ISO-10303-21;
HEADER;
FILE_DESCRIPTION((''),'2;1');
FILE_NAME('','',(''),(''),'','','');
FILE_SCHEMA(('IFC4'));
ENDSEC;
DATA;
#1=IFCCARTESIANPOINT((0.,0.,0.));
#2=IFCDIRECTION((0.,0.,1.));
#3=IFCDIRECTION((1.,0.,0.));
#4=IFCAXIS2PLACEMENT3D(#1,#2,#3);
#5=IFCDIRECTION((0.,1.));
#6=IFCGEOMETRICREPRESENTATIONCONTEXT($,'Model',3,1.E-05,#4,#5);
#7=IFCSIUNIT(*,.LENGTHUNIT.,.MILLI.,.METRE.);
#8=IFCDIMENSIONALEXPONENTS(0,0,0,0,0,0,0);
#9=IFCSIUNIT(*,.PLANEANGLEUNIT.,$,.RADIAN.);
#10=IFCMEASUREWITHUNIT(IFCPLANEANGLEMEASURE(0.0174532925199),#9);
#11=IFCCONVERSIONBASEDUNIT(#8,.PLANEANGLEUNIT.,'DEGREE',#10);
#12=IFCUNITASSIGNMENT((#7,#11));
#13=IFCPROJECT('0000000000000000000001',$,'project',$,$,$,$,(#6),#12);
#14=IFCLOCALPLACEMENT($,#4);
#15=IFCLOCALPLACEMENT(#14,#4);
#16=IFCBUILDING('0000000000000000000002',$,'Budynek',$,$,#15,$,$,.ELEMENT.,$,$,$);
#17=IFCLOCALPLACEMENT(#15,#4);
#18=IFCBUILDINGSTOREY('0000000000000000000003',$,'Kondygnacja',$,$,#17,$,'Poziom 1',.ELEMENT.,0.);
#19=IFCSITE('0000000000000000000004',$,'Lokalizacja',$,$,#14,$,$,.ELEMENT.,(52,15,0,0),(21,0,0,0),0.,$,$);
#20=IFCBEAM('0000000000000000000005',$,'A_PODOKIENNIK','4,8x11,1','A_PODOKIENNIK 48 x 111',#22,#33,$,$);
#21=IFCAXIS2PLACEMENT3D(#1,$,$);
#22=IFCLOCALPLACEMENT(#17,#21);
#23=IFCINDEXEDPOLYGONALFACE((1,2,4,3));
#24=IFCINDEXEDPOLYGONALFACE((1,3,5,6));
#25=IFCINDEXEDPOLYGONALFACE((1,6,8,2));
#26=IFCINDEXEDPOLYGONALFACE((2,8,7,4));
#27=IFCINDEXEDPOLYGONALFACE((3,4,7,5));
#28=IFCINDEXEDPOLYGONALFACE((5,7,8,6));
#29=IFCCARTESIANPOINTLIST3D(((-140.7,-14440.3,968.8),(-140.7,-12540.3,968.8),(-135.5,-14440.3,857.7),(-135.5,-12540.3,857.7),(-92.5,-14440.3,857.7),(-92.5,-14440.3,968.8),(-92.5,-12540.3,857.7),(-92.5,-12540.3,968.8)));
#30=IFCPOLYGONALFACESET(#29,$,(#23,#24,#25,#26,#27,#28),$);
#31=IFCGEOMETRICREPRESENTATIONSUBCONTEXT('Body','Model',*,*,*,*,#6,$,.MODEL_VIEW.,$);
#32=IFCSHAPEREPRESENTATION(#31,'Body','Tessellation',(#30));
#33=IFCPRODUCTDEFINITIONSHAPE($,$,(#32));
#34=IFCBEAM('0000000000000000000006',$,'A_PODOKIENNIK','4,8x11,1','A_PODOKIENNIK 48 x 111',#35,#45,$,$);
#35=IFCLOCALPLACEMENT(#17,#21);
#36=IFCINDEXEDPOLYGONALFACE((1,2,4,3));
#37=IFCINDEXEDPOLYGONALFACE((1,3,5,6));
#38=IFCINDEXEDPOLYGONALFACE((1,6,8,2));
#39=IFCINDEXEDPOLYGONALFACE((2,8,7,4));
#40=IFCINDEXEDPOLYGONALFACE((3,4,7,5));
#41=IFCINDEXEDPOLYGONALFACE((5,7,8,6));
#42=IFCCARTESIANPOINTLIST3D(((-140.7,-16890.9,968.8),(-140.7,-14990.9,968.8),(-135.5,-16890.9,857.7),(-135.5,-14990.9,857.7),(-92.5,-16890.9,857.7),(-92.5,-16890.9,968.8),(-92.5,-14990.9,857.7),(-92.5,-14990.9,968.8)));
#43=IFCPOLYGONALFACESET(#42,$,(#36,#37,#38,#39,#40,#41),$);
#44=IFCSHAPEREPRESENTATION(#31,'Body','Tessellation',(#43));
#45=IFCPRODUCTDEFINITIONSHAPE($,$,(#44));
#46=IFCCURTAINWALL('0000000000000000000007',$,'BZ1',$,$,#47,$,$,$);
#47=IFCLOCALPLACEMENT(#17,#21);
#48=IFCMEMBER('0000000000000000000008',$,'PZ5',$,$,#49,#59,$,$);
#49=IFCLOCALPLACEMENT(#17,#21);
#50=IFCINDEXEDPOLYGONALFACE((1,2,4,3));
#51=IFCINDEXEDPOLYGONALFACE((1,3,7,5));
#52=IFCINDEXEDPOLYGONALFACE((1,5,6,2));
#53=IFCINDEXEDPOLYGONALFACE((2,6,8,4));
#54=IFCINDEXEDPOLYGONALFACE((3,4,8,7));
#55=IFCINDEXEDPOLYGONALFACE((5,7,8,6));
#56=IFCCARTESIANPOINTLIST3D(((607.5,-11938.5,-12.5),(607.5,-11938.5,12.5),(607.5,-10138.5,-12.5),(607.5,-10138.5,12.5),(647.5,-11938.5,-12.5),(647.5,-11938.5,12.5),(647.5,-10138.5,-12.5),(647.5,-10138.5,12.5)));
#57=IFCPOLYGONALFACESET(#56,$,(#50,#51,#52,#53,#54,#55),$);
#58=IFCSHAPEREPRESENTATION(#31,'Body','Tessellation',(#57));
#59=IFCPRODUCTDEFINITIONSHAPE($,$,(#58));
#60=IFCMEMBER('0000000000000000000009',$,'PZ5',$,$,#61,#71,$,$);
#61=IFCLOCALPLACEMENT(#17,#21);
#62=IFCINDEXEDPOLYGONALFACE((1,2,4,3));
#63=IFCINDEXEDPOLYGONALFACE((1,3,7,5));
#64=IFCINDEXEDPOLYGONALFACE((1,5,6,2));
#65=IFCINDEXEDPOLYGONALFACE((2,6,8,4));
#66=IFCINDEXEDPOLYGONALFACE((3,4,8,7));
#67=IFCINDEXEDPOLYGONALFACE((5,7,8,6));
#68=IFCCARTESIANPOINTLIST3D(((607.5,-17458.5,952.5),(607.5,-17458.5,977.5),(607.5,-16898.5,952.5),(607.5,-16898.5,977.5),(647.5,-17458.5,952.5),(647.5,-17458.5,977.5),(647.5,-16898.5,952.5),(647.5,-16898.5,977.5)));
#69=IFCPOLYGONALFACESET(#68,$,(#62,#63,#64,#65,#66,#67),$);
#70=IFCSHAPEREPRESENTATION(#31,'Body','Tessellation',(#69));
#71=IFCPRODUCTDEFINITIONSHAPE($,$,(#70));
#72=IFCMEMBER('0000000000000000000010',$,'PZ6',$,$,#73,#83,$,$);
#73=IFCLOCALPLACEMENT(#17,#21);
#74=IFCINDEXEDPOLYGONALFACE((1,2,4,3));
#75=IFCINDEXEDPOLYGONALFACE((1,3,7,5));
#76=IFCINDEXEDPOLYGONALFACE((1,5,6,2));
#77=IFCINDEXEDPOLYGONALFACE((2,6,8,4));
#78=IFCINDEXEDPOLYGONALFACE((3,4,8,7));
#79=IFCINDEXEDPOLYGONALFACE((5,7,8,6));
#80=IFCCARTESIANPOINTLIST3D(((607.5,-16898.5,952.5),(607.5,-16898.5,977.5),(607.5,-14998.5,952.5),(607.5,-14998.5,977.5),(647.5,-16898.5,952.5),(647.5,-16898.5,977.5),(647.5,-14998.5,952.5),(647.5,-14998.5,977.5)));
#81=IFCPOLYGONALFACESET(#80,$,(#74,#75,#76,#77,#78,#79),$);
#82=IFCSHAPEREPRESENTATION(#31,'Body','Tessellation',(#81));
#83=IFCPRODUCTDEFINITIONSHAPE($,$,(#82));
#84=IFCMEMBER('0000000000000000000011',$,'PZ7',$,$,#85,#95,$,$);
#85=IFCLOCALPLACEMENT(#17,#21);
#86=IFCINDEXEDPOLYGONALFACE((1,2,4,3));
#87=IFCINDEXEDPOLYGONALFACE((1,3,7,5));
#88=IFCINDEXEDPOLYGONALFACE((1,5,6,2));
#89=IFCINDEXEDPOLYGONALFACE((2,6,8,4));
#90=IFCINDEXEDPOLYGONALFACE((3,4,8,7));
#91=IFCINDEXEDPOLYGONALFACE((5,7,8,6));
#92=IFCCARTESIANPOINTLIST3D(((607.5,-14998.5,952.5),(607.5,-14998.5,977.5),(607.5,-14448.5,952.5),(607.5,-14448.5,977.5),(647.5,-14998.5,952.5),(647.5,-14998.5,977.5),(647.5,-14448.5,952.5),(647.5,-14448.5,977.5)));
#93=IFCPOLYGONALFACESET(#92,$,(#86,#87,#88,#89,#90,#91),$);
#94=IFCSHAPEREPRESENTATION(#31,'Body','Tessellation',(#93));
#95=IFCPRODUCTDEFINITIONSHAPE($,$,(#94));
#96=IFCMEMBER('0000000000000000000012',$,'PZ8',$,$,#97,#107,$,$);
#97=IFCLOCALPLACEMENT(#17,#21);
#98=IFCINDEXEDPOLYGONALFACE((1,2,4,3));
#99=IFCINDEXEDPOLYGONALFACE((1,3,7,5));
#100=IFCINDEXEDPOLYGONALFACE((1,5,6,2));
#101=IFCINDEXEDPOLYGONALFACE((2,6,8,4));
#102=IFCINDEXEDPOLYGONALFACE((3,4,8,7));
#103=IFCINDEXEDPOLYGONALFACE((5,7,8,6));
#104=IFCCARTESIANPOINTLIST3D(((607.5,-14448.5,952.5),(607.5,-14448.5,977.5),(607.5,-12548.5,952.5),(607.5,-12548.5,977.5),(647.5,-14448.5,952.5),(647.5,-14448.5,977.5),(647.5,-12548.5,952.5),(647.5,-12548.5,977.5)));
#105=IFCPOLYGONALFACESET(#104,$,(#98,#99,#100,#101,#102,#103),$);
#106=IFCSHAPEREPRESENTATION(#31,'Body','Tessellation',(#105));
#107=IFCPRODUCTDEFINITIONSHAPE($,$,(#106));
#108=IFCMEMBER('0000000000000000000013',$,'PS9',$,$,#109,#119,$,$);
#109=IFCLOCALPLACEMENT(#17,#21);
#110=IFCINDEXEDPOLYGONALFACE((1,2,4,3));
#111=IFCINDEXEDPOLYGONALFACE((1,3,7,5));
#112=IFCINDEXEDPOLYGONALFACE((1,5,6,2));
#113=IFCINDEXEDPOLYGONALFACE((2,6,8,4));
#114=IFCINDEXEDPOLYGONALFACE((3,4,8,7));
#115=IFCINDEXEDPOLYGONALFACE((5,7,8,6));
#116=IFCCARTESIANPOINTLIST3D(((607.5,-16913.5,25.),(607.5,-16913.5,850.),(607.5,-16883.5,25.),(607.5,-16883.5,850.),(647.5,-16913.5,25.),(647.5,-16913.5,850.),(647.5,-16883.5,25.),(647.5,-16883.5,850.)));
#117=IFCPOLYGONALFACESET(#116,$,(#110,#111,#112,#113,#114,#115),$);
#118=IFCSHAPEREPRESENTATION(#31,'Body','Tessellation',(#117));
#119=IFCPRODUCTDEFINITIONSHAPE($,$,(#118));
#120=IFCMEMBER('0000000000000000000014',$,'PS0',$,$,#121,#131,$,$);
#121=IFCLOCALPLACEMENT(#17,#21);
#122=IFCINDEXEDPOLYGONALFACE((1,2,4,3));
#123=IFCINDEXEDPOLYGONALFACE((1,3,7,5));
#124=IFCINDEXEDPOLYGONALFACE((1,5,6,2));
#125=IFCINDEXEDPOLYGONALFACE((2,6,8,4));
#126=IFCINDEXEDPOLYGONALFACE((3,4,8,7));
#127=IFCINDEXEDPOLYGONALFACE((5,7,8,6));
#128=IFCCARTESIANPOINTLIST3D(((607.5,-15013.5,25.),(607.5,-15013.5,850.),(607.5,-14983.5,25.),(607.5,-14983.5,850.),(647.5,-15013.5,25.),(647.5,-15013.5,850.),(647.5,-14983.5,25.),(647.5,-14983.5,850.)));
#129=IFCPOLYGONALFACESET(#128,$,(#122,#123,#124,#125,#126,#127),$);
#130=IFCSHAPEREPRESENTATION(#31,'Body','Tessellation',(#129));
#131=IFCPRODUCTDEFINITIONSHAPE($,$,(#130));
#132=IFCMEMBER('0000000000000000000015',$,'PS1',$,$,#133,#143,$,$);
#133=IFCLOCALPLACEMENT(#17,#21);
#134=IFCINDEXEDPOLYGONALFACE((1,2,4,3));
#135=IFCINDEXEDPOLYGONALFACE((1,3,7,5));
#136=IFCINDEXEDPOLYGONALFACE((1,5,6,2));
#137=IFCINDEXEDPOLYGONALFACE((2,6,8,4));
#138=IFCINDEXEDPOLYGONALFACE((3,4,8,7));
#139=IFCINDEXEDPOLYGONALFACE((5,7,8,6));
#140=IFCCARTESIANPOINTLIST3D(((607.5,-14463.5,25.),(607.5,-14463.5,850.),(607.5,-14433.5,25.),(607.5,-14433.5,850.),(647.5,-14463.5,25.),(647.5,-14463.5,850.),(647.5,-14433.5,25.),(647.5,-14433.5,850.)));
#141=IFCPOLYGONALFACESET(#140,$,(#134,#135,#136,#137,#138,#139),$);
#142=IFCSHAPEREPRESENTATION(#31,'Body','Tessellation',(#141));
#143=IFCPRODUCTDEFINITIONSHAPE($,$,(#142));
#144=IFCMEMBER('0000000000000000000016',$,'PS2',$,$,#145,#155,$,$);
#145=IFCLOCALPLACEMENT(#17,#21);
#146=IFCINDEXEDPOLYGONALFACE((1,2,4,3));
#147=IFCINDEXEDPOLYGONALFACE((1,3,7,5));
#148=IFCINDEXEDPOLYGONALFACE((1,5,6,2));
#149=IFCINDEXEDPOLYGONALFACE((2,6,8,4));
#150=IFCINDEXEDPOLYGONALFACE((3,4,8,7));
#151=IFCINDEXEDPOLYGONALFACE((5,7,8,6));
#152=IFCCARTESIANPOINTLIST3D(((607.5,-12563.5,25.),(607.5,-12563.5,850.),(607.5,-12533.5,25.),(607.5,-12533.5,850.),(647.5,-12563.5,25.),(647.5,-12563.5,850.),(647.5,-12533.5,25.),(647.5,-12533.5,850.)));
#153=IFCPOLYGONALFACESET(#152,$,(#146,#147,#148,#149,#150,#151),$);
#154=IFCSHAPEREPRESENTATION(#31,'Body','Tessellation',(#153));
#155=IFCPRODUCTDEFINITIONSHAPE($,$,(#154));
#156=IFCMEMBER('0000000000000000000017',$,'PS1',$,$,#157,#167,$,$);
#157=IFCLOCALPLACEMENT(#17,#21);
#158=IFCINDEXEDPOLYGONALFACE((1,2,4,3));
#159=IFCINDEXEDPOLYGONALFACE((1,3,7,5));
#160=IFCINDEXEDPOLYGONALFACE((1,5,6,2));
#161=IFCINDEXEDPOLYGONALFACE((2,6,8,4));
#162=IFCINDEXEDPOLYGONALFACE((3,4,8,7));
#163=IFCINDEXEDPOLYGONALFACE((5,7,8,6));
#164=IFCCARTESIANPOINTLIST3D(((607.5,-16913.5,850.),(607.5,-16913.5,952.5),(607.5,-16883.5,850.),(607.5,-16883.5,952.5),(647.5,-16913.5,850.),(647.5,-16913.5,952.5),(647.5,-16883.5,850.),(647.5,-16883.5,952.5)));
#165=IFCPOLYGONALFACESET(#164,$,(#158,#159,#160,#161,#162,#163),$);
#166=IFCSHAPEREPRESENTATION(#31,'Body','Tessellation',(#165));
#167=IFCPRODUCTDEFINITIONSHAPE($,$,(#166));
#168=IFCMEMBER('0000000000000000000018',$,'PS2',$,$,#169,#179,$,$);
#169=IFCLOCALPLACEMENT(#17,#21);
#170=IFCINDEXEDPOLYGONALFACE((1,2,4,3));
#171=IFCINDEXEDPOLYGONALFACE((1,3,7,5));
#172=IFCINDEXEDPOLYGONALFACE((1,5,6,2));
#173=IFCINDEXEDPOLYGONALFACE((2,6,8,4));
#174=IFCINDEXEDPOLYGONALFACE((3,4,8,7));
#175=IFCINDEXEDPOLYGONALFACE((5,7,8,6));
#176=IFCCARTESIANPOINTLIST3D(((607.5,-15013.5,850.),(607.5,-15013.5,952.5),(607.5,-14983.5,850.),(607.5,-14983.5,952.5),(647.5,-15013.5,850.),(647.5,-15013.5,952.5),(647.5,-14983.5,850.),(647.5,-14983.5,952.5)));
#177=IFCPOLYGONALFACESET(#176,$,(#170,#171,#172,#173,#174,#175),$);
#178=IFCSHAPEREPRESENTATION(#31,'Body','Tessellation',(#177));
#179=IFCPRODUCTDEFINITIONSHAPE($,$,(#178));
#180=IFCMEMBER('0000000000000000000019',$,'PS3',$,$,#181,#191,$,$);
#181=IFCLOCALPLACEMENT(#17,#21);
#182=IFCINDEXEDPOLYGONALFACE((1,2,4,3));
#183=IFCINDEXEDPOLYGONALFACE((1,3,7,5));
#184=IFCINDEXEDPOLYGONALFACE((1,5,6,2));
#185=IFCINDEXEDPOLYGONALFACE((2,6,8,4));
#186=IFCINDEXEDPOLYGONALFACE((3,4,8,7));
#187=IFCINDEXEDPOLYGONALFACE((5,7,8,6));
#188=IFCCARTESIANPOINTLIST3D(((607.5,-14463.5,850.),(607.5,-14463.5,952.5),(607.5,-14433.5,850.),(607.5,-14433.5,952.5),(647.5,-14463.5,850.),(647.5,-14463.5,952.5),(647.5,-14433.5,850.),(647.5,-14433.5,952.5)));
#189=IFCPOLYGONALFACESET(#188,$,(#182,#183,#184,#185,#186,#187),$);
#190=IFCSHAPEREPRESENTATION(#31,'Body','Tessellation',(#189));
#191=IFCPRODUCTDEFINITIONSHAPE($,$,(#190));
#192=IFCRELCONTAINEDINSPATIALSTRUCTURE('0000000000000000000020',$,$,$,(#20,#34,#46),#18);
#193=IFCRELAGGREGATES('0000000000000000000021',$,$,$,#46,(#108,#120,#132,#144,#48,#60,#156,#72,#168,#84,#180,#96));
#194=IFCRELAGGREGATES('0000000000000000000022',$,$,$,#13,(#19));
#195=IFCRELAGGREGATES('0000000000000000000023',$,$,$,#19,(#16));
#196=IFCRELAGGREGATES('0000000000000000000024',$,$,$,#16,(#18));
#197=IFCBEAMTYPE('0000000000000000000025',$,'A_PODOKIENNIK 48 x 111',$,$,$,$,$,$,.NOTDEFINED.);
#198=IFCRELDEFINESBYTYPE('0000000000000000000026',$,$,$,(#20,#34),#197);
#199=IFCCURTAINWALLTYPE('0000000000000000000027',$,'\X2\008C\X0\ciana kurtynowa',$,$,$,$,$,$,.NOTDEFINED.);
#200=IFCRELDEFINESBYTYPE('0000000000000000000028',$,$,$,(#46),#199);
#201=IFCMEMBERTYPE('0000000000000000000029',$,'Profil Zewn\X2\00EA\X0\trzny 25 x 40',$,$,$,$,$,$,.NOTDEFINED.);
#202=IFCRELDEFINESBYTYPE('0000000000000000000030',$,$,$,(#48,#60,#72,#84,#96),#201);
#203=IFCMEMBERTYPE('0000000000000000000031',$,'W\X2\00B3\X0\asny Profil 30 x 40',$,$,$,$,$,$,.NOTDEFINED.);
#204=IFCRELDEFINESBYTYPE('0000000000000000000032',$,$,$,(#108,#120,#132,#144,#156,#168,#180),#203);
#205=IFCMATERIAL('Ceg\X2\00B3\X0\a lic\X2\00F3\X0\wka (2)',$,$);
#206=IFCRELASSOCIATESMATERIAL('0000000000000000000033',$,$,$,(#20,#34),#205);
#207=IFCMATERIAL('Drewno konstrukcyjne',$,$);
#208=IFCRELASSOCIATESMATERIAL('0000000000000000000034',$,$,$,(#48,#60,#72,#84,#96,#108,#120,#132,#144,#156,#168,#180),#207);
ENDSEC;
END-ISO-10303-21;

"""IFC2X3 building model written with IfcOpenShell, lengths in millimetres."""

from ifc_helpers import new_model, entity, si_unit, converted_unit, direction, frame, origin_with_axes, place, context, subcontext, project, spatial, polyline, outline, extrude, material, type_object, element, aggregate, save


model = new_model("IFC2X3")

# Units and contexts
model_context = context("Model", 3, precision=1e-05, world=origin_with_axes(), true_north=direction((0.0, 1.0)))
body_context = subcontext(model_context, "Body", "Model", "MODEL_VIEW")
ifc_project = project(units=[si_unit("LENGTHUNIT", "METRE", prefix="MILLI"), converted_unit("PLANEANGLEUNIT", "DEGREE", entity("IfcPlaneAngleMeasure", 0.0174532925199), si_unit("PLANEANGLEUNIT", "RADIAN"), dimensions=[0, 0, 0, 0, 0, 0, 0])], contexts=[model_context])

# Site, building, storey
site_placement = place(None, origin_with_axes())
site = spatial("IfcSite", under=ifc_project, at=site_placement, Name="Lokalizacja", CompositionType="ELEMENT", RefLatitude=(52, 15, 0, 0), RefLongitude=(21, 0, 0, 0), RefElevation=0.0)
building_placement = place(site_placement, origin_with_axes())
building = spatial("IfcBuilding", under=site, at=building_placement, Name="Budynek", CompositionType="ELEMENT")
storey_placement = place(building_placement, origin_with_axes())
storey = spatial("IfcBuildingStorey", under=building, at=storey_placement, Name="Kondygnacja", LongName="Poziom 1", CompositionType="ELEMENT", Elevation=0.0)

# Beams
ifc_material_1 = material(Name="Ceg³a licówka (2)")
beam_type = type_object("IfcBeamType", Name="A_PODOKIENNIK 48 x 111", PredefinedType="NOTDEFINED")
for number, where, z_axis, x_axis, name in (
    (1, (-92.5, -12540.3, 857.7), (0.0, 0.0, 1.0), (-1.0, 0.0, 0.0), "A_PODOKIENNIK"),
    (2, (-92.5, -14990.9, 857.7), (0.0, 0.0, 1.0), (-1.0, 0.0, 0.0), "A_PODOKIENNIK"),
):
    element("IfcBeam", number, at=place(storey_placement, frame(where, z_axis=z_axis, x_axis=x_axis)), inside=storey, type_object=beam_type, material=ifc_material_1, Name=name, Description="4,8x11,1", ObjectType="A_PODOKIENNIK 48 x 111", context=body_context, shape_type="SweptSolid", body=[
        extrude(outline(polyline([(0.0, 0.0), (43.0, 0.0), (48.2, 111.1), (0.0, 111.1), (0.0, 0.0)])), frame((0.0, 1900.0, 0.0), z_axis=(0.0, -1.0, 0.0), x_axis=(1.0, 0.0, 0.0)), (0.0, 0.0, 1.0), 1900.0),
    ])

# Curtain wall, members
curtain_wall_type = type_object("IfcCurtainWallType", Name="\u008cciana kurtynowa", PredefinedType="NOTDEFINED")
curtain_wall_placement = place(storey_placement, frame((647.5, -18408.5, 0.0), z_axis=(0.0, 0.0, 1.0), x_axis=(1.0, 0.0, 0.0)))
curtain_wall = element("IfcCurtainWall", 3, at=curtain_wall_placement, inside=storey, type_object=curtain_wall_type, Name="BZ1")
ifc_material_2 = material(Name="Drewno konstrukcyjne")
member_type_1 = type_object("IfcMemberType", Name="Profil Zewnêtrzny 25 x 40", PredefinedType="NOTDEFINED")
member_1_placement = place(curtain_wall_placement, frame((0.0, 6470.0, 0.0), z_axis=(0.0, 1.0, 0.0), x_axis=(0.0, 0.0, 1.0)))
member_1 = element("IfcMember", 4, at=member_1_placement, type_object=member_type_1, material=ifc_material_2, Name="PZ5", context=body_context, shape_type="SweptSolid", body=[
    extrude(outline(polyline([(-40.0, -12.5), (0.0, -12.5), (0.0, 12.5), (-40.0, 12.5), (-40.0, -12.5)])), frame((0.0, 0.0, 0.0), z_axis=(0.0, 0.0, 1.0), x_axis=(0.0, 1.0, 0.0)), (0.0, 0.0, 1.0), 1800.0),
])
member_2_placement = place(curtain_wall_placement, frame((0.0, 1510.0, 965.0), z_axis=(0.0, -1.0, 0.0), x_axis=(0.0, 0.0, -1.0)))
member_2 = element("IfcMember", 5, at=member_2_placement, type_object=member_type_1, material=ifc_material_2, Name="PZ5", context=body_context, shape_type="SweptSolid", body=[
    extrude(outline(polyline([(40.0, 12.5), (0.0, 12.5), (0.0, -12.5), (40.0, -12.5), (40.0, 12.5)])), frame((0.0, 0.0, 0.0), z_axis=(0.0, 0.0, 1.0), x_axis=(0.0, -1.0, 0.0)), (0.0, 0.0, 1.0), 560.0),
])
member_3_placement = place(curtain_wall_placement, frame((0.0, 3410.0, 965.0), z_axis=(0.0, -1.0, 0.0), x_axis=(0.0, 0.0, -1.0)))
member_3 = element("IfcMember", 6, at=member_3_placement, type_object=member_type_1, material=ifc_material_2, Name="PZ6", context=body_context, shape_type="SweptSolid", body=[
    extrude(outline(polyline([(40.0, 12.5), (0.0, 12.5), (0.0, -12.5), (40.0, -12.5), (40.0, 12.5)])), frame((0.0, 0.0, 0.0), z_axis=(0.0, 0.0, 1.0), x_axis=(0.0, -1.0, 0.0)), (0.0, 0.0, 1.0), 1900.0),
])
member_4_placement = place(curtain_wall_placement, frame((0.0, 3960.0, 965.0), z_axis=(0.0, -1.0, 0.0), x_axis=(0.0, 0.0, -1.0)))
member_4 = element("IfcMember", 7, at=member_4_placement, type_object=member_type_1, material=ifc_material_2, Name="PZ7", context=body_context, shape_type="SweptSolid", body=[
    extrude(outline(polyline([(40.0, 12.5), (0.0, 12.5), (0.0, -12.5), (40.0, -12.5), (40.0, 12.5)])), frame((0.0, 0.0, 0.0), z_axis=(0.0, 0.0, 1.0), x_axis=(0.0, -1.0, 0.0)), (0.0, 0.0, 1.0), 550.0),
])
member_5_placement = place(curtain_wall_placement, frame((0.0, 5860.0, 965.0), z_axis=(0.0, -1.0, 0.0), x_axis=(0.0, 0.0, -1.0)))
member_5 = element("IfcMember", 8, at=member_5_placement, type_object=member_type_1, material=ifc_material_2, Name="PZ8", context=body_context, shape_type="SweptSolid", body=[
    extrude(outline(polyline([(40.0, 12.5), (0.0, 12.5), (0.0, -12.5), (40.0, -12.5), (40.0, 12.5)])), frame((0.0, 0.0, 0.0), z_axis=(0.0, 0.0, 1.0), x_axis=(0.0, -1.0, 0.0)), (0.0, 0.0, 1.0), 1900.0),
])
member_type_2 = type_object("IfcMemberType", Name="W³asny Profil 30 x 40", PredefinedType="NOTDEFINED")
member_6_placement = place(curtain_wall_placement, frame((0.0, 1510.0, 0.0), z_axis=(0.0, 0.0, 1.0), x_axis=(0.0, -1.0, 0.0)))
member_6 = element("IfcMember", 9, at=member_6_placement, type_object=member_type_2, material=ifc_material_2, Name="PS9", context=body_context, shape_type="SweptSolid", body=[
    extrude(outline(polyline([(-40.0, -15.0), (0.0, -15.0), (0.0, 15.0), (-40.0, 15.0), (-40.0, -15.0)])), frame((0.0, 0.0, 25.0), z_axis=(0.0, 0.0, 1.0), x_axis=(0.0, 1.0, 0.0)), (0.0, 0.0, 1.0), 825.0),
])
member_7_placement = place(curtain_wall_placement, frame((0.0, 3410.0, 0.0), z_axis=(0.0, 0.0, 1.0), x_axis=(0.0, -1.0, 0.0)))
member_7 = element("IfcMember", 10, at=member_7_placement, type_object=member_type_2, material=ifc_material_2, Name="PS0", context=body_context, shape_type="SweptSolid", body=[
    extrude(outline(polyline([(-40.0, -15.0), (0.0, -15.0), (0.0, 15.0), (-40.0, 15.0), (-40.0, -15.0)])), frame((0.0, 0.0, 25.0), z_axis=(0.0, 0.0, 1.0), x_axis=(0.0, 1.0, 0.0)), (0.0, 0.0, 1.0), 825.0),
])
member_8_placement = place(curtain_wall_placement, frame((0.0, 3960.0, 0.0), z_axis=(0.0, 0.0, 1.0), x_axis=(0.0, -1.0, 0.0)))
member_8 = element("IfcMember", 11, at=member_8_placement, type_object=member_type_2, material=ifc_material_2, Name="PS1", context=body_context, shape_type="SweptSolid", body=[
    extrude(outline(polyline([(-40.0, -15.0), (0.0, -15.0), (0.0, 15.0), (-40.0, 15.0), (-40.0, -15.0)])), frame((0.0, 0.0, 25.0), z_axis=(0.0, 0.0, 1.0), x_axis=(0.0, 1.0, 0.0)), (0.0, 0.0, 1.0), 825.0),
])
member_9_placement = place(curtain_wall_placement, frame((0.0, 5860.0, 0.0), z_axis=(0.0, 0.0, 1.0), x_axis=(0.0, -1.0, 0.0)))
member_9 = element("IfcMember", 12, at=member_9_placement, type_object=member_type_2, material=ifc_material_2, Name="PS2", context=body_context, shape_type="SweptSolid", body=[
    extrude(outline(polyline([(-40.0, -15.0), (0.0, -15.0), (0.0, 15.0), (-40.0, 15.0), (-40.0, -15.0)])), frame((0.0, 0.0, 25.0), z_axis=(0.0, 0.0, 1.0), x_axis=(0.0, 1.0, 0.0)), (0.0, 0.0, 1.0), 825.0),
])
member_10_placement = place(curtain_wall_placement, frame((0.0, 1510.0, 850.0), z_axis=(0.0, 0.0, 1.0), x_axis=(0.0, -1.0, 0.0)))
member_10 = element("IfcMember", 13, at=member_10_placement, type_object=member_type_2, material=ifc_material_2, Name="PS1", context=body_context, shape_type="SweptSolid", body=[
    extrude(outline(polyline([(-40.0, -15.0), (0.0, -15.0), (0.0, 15.0), (-40.0, 15.0), (-40.0, -15.0)])), frame((0.0, 0.0, 0.0), z_axis=(0.0, 0.0, 1.0), x_axis=(0.0, 1.0, 0.0)), (0.0, 0.0, 1.0), 102.5),
])
member_11_placement = place(curtain_wall_placement, frame((0.0, 3410.0, 850.0), z_axis=(0.0, 0.0, 1.0), x_axis=(0.0, -1.0, 0.0)))
member_11 = element("IfcMember", 14, at=member_11_placement, type_object=member_type_2, material=ifc_material_2, Name="PS2", context=body_context, shape_type="SweptSolid", body=[
    extrude(outline(polyline([(-40.0, -15.0), (0.0, -15.0), (0.0, 15.0), (-40.0, 15.0), (-40.0, -15.0)])), frame((0.0, 0.0, 0.0), z_axis=(0.0, 0.0, 1.0), x_axis=(0.0, 1.0, 0.0)), (0.0, 0.0, 1.0), 102.5),
])
member_12_placement = place(curtain_wall_placement, frame((0.0, 3960.0, 850.0), z_axis=(0.0, 0.0, 1.0), x_axis=(0.0, -1.0, 0.0)))
member_12 = element("IfcMember", 15, at=member_12_placement, type_object=member_type_2, material=ifc_material_2, Name="PS3", context=body_context, shape_type="SweptSolid", body=[
    extrude(outline(polyline([(-40.0, -15.0), (0.0, -15.0), (0.0, 15.0), (-40.0, 15.0), (-40.0, -15.0)])), frame((0.0, 0.0, 0.0), z_axis=(0.0, 0.0, 1.0), x_axis=(0.0, 1.0, 0.0)), (0.0, 0.0, 1.0), 102.5),
])
aggregate(curtain_wall, [member_6, member_7, member_8, member_9, member_1, member_2, member_10, member_3, member_11, member_4, member_12, member_5])

save(model, "model.ifc")
